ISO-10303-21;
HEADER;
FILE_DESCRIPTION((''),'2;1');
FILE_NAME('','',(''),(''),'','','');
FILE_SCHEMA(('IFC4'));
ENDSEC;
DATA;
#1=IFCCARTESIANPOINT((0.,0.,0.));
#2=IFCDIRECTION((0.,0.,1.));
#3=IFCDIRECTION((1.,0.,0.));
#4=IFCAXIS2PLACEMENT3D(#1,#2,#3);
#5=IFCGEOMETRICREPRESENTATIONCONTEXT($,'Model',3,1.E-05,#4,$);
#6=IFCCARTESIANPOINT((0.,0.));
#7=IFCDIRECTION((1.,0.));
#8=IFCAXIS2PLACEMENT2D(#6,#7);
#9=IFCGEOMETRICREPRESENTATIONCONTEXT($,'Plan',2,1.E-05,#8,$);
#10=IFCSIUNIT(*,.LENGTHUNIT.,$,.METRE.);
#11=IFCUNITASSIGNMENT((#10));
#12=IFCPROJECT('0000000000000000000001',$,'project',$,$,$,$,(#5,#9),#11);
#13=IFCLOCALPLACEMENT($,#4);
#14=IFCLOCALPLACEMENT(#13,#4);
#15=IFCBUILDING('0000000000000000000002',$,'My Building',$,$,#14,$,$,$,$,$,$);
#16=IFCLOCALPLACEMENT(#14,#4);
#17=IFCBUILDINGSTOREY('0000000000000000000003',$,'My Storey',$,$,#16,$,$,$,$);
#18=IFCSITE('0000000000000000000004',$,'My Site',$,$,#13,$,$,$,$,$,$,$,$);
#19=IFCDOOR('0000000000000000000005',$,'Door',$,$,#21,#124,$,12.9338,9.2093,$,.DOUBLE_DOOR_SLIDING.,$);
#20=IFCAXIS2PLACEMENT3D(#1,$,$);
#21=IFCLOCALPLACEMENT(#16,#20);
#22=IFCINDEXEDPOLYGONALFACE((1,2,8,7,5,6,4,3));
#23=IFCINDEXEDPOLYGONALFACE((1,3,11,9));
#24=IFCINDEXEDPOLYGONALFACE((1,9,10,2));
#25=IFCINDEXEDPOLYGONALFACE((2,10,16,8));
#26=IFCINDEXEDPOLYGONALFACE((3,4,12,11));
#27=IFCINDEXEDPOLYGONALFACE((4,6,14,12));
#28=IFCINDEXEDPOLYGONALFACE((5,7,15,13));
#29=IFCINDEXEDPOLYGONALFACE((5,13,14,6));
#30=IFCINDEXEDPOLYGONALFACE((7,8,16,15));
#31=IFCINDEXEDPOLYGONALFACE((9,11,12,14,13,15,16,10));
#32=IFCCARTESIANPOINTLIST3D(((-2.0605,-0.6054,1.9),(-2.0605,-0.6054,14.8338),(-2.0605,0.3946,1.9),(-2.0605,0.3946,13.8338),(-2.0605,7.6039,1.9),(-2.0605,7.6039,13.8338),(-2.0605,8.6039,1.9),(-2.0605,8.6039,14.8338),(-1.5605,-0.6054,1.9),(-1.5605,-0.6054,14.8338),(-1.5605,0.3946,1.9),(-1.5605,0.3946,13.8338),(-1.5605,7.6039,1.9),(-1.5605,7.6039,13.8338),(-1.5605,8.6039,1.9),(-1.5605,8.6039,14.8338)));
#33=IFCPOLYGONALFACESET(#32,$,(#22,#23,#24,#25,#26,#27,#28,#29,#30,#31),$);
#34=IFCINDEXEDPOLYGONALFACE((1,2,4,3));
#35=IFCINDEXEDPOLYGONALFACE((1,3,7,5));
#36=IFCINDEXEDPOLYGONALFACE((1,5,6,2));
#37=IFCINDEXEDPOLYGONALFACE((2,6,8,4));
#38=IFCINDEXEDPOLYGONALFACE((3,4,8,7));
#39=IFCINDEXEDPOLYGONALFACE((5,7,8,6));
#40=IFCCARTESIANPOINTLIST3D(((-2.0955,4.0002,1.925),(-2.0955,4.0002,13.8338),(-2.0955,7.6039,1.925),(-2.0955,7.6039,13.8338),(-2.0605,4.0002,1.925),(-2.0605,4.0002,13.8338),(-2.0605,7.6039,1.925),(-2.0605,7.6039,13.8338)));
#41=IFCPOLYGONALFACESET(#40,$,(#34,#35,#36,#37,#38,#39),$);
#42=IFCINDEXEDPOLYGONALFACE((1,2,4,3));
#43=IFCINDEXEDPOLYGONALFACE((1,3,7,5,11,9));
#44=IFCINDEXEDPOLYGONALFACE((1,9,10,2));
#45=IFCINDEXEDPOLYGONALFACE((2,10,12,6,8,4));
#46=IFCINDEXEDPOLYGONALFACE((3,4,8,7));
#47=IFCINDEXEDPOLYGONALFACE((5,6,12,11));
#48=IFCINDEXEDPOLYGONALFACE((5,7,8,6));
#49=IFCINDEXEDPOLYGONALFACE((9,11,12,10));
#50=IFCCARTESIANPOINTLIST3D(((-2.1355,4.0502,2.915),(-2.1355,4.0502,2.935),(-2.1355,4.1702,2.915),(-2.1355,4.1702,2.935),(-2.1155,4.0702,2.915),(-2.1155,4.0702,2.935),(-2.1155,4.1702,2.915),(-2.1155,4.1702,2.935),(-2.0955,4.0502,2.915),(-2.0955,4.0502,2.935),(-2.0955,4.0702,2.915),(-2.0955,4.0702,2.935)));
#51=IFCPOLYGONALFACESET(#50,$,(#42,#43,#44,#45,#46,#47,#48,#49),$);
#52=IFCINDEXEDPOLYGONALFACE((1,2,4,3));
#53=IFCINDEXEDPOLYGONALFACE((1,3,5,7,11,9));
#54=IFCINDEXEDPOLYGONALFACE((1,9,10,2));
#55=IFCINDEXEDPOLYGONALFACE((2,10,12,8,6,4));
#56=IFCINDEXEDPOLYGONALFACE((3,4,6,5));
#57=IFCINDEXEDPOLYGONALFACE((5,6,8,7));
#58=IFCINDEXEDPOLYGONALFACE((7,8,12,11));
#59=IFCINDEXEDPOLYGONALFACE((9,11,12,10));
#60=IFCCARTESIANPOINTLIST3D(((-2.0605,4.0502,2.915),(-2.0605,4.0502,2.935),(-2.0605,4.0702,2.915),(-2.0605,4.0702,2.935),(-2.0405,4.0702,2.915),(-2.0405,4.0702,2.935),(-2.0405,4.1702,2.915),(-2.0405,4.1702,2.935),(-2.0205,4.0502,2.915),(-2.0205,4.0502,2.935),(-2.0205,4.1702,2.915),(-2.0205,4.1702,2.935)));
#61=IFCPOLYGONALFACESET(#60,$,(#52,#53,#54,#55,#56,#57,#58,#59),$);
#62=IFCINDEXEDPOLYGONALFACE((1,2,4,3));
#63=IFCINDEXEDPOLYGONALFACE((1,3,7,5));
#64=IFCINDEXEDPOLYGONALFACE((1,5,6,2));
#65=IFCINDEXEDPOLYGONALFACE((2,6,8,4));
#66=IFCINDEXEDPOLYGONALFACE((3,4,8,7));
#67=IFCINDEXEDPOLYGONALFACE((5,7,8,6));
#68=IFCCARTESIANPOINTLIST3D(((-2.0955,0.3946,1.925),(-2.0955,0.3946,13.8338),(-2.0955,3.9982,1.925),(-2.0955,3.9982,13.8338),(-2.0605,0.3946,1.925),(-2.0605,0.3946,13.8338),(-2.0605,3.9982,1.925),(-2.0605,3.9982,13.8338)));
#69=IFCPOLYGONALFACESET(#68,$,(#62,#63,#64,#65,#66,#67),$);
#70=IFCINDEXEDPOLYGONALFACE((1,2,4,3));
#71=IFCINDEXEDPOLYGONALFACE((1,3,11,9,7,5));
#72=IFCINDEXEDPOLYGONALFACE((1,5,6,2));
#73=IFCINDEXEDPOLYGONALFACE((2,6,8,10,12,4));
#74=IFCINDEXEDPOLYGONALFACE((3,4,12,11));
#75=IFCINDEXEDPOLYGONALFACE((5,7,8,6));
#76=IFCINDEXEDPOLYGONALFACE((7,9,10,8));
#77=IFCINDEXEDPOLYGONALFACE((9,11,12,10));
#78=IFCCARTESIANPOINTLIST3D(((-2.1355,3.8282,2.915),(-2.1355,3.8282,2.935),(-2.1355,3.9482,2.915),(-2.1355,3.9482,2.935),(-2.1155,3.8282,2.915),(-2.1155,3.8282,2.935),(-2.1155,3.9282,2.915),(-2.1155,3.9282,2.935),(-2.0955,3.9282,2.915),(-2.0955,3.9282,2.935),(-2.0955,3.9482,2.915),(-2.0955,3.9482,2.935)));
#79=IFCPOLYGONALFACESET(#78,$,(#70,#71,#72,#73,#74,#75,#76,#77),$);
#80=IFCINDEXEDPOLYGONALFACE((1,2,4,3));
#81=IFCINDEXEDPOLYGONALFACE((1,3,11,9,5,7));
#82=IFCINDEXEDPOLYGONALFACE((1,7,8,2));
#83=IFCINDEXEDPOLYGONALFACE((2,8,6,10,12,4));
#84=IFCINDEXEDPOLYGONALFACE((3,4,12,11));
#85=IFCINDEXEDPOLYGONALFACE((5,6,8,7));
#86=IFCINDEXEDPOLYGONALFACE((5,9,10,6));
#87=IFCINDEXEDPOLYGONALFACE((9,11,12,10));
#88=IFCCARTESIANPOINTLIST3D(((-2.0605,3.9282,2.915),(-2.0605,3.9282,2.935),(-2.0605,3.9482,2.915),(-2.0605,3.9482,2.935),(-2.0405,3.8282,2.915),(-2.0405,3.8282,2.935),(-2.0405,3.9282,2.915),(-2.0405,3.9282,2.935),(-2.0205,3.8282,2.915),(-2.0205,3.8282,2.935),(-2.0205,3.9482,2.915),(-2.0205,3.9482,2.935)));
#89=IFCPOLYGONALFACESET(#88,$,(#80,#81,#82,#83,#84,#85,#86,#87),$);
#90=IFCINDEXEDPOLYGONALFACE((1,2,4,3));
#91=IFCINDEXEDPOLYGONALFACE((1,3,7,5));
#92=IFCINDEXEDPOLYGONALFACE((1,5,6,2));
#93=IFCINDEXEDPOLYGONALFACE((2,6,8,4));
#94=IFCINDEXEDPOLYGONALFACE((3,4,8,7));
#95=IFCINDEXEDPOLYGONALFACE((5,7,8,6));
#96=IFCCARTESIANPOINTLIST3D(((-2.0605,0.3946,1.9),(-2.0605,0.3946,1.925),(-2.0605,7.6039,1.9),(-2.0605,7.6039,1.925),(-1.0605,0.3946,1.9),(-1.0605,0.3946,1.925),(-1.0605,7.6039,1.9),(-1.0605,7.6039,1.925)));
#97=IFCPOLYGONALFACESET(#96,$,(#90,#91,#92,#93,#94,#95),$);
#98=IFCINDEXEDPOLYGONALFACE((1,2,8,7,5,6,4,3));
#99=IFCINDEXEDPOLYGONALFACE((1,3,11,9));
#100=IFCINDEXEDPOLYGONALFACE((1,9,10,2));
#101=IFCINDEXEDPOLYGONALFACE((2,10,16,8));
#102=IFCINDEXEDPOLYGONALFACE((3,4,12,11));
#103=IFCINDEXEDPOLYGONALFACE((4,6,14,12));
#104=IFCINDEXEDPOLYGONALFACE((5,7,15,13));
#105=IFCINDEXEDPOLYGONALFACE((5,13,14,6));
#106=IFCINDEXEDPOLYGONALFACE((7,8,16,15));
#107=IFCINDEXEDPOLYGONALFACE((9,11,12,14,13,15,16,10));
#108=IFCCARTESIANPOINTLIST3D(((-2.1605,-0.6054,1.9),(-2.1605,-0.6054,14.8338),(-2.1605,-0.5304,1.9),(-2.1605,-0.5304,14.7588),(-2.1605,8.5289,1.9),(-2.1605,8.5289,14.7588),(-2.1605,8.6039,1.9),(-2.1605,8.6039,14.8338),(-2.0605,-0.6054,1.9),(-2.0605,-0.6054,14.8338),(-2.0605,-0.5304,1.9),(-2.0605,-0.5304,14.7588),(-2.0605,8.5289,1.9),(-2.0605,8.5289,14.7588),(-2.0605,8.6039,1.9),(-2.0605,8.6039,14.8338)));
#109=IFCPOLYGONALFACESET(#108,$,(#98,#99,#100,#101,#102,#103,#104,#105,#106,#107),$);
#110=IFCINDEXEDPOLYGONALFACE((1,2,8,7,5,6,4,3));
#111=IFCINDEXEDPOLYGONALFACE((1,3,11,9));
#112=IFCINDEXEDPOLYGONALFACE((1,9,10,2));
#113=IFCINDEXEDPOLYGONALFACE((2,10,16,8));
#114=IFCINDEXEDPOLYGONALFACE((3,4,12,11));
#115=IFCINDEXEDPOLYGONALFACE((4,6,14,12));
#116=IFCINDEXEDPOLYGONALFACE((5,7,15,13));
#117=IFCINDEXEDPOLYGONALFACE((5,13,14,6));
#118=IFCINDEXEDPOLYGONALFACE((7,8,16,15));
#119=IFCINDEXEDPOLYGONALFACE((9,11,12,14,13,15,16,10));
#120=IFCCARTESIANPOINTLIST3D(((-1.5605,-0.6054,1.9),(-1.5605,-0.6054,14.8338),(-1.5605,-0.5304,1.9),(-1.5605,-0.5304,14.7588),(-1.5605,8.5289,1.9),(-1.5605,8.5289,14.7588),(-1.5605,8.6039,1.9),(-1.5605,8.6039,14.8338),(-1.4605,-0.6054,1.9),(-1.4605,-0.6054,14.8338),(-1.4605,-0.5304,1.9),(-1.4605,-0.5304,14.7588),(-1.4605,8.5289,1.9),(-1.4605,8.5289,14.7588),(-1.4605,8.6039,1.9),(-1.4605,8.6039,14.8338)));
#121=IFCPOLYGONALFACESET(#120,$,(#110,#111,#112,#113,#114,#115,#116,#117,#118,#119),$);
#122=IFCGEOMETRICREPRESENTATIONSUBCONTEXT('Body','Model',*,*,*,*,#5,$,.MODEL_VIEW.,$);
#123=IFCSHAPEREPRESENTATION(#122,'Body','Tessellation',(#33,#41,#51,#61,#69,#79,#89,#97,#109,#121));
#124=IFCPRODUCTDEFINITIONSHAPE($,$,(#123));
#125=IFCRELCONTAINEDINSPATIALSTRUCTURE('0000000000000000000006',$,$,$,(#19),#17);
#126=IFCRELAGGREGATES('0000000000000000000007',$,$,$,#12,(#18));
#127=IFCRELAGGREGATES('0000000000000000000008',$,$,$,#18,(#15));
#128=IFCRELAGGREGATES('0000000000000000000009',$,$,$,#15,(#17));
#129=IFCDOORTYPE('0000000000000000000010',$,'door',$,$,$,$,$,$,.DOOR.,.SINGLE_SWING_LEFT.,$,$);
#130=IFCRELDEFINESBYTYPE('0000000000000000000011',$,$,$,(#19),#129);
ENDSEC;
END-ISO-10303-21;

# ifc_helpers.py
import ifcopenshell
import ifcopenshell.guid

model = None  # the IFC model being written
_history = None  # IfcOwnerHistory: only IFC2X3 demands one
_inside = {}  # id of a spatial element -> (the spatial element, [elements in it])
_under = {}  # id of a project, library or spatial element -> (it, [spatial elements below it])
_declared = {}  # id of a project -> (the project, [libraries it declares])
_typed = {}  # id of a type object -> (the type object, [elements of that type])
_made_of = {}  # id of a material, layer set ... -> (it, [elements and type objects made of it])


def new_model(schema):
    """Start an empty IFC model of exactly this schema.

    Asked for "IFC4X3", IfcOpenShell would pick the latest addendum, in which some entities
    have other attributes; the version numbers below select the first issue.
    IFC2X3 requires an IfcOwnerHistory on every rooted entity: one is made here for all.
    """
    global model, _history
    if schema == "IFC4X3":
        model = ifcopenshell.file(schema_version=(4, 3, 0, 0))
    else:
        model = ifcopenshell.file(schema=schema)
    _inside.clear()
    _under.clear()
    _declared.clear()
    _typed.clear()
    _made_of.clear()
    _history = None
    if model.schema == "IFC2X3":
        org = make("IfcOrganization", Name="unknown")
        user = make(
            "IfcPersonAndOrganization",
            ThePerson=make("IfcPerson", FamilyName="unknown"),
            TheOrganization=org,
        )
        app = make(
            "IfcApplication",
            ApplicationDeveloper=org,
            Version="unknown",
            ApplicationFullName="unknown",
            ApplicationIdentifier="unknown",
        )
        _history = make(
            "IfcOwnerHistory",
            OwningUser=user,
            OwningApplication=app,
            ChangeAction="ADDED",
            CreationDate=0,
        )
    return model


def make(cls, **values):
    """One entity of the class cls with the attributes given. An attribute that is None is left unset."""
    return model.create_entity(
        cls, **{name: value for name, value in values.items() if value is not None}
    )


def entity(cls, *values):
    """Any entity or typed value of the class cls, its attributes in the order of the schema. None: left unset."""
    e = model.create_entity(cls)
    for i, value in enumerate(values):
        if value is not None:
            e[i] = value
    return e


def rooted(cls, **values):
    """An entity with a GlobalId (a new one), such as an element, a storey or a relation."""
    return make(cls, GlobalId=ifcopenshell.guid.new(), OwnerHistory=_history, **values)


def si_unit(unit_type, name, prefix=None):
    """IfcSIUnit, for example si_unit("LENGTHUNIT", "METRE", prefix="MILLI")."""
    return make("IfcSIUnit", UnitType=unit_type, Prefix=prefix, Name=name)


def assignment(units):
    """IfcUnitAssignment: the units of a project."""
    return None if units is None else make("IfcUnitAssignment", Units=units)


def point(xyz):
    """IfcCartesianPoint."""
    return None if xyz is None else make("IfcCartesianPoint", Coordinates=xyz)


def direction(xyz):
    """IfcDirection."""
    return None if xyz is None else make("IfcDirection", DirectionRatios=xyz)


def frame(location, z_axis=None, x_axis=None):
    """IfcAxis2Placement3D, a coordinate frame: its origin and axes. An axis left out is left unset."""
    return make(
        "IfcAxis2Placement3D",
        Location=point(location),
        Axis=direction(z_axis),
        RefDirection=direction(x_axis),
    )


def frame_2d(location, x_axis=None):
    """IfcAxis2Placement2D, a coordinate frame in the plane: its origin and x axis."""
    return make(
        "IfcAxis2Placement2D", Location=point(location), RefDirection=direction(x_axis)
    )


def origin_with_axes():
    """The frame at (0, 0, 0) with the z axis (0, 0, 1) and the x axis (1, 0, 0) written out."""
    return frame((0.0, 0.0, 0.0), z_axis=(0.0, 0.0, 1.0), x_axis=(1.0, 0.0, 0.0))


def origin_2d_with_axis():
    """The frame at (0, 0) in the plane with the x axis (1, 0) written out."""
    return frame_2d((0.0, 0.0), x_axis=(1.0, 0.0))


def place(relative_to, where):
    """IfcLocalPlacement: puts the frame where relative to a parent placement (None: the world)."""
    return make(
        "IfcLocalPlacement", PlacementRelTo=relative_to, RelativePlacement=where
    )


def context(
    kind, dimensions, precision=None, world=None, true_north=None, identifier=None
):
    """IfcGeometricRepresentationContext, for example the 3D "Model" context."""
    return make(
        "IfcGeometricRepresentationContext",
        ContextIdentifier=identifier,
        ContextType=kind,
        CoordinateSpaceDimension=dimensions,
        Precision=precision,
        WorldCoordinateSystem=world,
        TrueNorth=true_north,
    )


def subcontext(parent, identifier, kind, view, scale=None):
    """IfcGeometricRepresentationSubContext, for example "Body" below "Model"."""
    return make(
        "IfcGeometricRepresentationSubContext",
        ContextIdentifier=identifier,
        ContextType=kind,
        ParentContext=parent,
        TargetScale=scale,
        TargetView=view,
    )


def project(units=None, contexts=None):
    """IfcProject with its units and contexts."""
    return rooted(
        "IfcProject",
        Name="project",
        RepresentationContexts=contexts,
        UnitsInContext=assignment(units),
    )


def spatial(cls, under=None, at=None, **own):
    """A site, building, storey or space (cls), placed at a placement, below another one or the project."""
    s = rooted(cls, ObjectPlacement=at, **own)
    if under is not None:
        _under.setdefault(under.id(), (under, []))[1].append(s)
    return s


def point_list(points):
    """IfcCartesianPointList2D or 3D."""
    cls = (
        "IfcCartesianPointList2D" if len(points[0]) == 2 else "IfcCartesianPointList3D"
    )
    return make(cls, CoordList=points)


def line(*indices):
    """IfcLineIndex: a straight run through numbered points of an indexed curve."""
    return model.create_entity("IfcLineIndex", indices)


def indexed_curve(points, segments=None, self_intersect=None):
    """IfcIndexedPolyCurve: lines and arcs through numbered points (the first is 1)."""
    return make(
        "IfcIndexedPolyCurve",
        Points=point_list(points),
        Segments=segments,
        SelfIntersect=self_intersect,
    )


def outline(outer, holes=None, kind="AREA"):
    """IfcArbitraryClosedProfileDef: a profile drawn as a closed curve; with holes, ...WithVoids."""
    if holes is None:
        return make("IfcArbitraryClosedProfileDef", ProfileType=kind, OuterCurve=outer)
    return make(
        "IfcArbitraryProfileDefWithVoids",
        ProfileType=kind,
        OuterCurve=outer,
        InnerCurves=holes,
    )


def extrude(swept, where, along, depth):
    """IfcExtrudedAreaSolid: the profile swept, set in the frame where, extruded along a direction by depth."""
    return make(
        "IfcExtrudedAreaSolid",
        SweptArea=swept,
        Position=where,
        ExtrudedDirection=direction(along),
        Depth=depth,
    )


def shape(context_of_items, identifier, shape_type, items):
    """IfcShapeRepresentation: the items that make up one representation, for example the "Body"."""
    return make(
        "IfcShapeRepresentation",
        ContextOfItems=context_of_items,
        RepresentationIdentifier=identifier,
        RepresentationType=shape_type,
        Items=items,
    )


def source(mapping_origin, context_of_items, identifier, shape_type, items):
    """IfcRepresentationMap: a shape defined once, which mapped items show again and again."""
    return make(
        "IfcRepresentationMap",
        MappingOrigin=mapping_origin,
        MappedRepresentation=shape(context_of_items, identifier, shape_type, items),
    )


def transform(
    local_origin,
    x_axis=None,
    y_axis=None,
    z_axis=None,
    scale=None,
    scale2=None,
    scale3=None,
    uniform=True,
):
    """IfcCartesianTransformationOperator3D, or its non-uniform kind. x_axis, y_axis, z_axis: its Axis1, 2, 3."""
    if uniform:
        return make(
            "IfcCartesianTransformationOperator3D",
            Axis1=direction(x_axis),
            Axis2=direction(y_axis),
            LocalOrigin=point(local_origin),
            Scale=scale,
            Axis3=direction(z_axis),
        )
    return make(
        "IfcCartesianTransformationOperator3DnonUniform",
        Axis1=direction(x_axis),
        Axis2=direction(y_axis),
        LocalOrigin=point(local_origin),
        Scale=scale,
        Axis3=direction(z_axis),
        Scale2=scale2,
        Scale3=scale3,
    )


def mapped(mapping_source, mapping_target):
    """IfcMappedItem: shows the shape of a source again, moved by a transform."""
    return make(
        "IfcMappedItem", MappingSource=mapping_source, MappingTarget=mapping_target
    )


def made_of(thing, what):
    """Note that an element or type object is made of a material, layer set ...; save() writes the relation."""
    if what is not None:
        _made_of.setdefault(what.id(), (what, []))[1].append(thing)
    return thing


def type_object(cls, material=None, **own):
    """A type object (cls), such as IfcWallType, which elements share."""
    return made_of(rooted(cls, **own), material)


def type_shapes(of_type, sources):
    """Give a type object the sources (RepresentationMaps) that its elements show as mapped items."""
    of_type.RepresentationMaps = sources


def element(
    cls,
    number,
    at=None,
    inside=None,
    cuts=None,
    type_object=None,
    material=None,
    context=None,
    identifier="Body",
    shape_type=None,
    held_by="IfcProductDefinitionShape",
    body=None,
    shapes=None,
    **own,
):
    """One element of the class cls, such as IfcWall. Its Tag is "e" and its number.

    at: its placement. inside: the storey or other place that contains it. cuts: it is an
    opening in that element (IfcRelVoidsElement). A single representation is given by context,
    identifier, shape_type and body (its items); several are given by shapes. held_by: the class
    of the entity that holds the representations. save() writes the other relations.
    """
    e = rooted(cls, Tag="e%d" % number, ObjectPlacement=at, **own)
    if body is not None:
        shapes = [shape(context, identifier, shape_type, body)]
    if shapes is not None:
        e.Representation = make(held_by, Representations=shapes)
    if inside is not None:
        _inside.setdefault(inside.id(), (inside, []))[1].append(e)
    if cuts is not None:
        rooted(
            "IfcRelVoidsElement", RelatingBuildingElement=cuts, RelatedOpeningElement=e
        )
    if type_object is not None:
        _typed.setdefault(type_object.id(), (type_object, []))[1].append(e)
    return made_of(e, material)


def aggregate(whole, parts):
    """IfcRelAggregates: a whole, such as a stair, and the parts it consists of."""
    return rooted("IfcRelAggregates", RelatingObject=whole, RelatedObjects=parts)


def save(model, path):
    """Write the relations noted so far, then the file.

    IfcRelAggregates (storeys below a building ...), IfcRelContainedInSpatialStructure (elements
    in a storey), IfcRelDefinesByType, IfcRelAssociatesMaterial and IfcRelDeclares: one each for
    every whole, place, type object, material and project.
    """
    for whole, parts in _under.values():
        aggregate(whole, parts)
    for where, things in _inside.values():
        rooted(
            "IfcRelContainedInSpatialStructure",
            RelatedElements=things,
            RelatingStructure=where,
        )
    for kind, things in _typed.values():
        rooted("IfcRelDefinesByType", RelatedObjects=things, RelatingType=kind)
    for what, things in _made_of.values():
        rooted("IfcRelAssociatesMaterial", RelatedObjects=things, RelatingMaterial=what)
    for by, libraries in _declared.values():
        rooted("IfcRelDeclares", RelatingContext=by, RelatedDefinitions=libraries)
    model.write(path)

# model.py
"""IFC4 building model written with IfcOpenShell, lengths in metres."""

from ifc_helpers import new_model, entity, si_unit, frame, origin_with_axes, origin_2d_with_axis, place, context, subcontext, project, spatial, line, indexed_curve, outline, extrude, shape, source, transform, mapped, type_object, type_shapes, element, save


model = new_model("IFC4")

# Units and contexts
model_context = context("Model", 3, precision=1e-05, world=origin_with_axes())
plan_context = context("Plan", 2, precision=1e-05, world=origin_2d_with_axis())
body_context_1 = subcontext(model_context, "Body", "Model", "MODEL_VIEW")
body_context_2 = subcontext(plan_context, "Body", "Plan", "PLAN_VIEW")
ifc_project = project(units=[si_unit("LENGTHUNIT", "METRE")], contexts=[model_context, plan_context])

# Site, building, storey
site_placement = place(None, origin_with_axes())
site = spatial("IfcSite", under=ifc_project, at=site_placement, Name="My Site")
building_placement = place(site_placement, origin_with_axes())
building = spatial("IfcBuilding", under=site, at=building_placement, Name="My Building")
storey_placement = place(building_placement, origin_with_axes())
storey = spatial("IfcBuildingStorey", under=building, at=storey_placement, Name="My Storey")

# Door
door_type = type_object("IfcDoorType", Name="door", OperationType="SINGLE_SWING_LEFT", PredefinedType="DOOR")
shared_shape_1 = source(origin_with_axes(), body_context_1, "Body", "SweptSolid", [
    extrude(outline(indexed_curve([(0.0, 0.0), (0.0, 12.9338), (9.2093, 12.9338), (9.2093, 0.0), (8.2093, 0.0), (8.2093, 11.9338), (1.0, 11.9338), (1.0, 0.0)], segments=[line(1, 2, 3, 4, 5, 6, 7, 8, 1)])), frame((0.0, 0.0, 0.0), z_axis=(0.0, -1.0, 0.0), x_axis=(1.0, 0.0, 0.0)), (0.0, 0.0, -1.0), 0.5),
    extrude(outline(indexed_curve([(0.0, 0.0), (3.6036, 0.0), (3.6036, 0.035), (0.0, 0.035)], segments=[line(1, 2, 3, 4, 1)])), frame((1.0, -0.035, 0.025), z_axis=(0.0, 0.0, 1.0), x_axis=(1.0, 0.0, 0.0)), (0.0, 0.0, 1.0), 11.9088),
    extrude(outline(indexed_curve([(0.0, 0.0), (0.0, -0.04), (-0.12, -0.04), (-0.12, -0.02), (-0.02, -0.02), (-0.02, 0.0)], segments=[line(1, 2, 3, 4, 5, 6, 1)])), frame((4.5536, -0.035, 1.015), z_axis=(0.0, 0.0, 1.0), x_axis=(1.0, 0.0, 0.0)), (0.0, 0.0, 1.0), 0.02),
    extrude(outline(indexed_curve([(0.0, 0.0), (0.0, 0.04), (-0.12, 0.04), (-0.12, 0.02), (-0.02, 0.02), (-0.02, 0.0)], segments=[line(1, 2, 3, 4, 5, 6, 1)])), frame((4.5536, 0.0, 1.015), z_axis=(0.0, 0.0, 1.0), x_axis=(1.0, 0.0, 0.0)), (0.0, 0.0, 1.0), 0.02),
    extrude(outline(indexed_curve([(0.0, 0.0), (-3.6036, 0.0), (-3.6036, 0.035), (0.0, 0.035)], segments=[line(1, 2, 3, 4, 1)])), frame((8.2093, -0.035, 0.025), z_axis=(0.0, 0.0, 1.0), x_axis=(1.0, 0.0, 0.0)), (0.0, 0.0, 1.0), 11.9088),
    extrude(outline(indexed_curve([(0.0, 0.0), (0.0, -0.04), (0.12, -0.04), (0.12, -0.02), (0.02, -0.02), (0.02, 0.0)], segments=[line(1, 2, 3, 4, 5, 6, 1)])), frame((4.6556, -0.035, 1.015), z_axis=(0.0, 0.0, 1.0), x_axis=(1.0, 0.0, 0.0)), (0.0, 0.0, 1.0), 0.02),
    extrude(outline(indexed_curve([(0.0, 0.0), (0.0, 0.04), (0.12, 0.04), (0.12, 0.02), (0.02, 0.02), (0.02, 0.0)], segments=[line(1, 2, 3, 4, 5, 6, 1)])), frame((4.6556, 0.0, 1.015), z_axis=(0.0, 0.0, 1.0), x_axis=(1.0, 0.0, 0.0)), (0.0, 0.0, 1.0), 0.02),
    extrude(outline(indexed_curve([(0.0, 0.0), (7.2093, 0.0), (7.2093, 1.0), (0.0, 1.0)], segments=[line(1, 2, 3, 4, 1)])), frame((1.0, 0.0, 0.0), z_axis=(0.0, 0.0, 1.0), x_axis=(1.0, 0.0, 0.0)), (0.0, 0.0, 1.0), 0.025),
    extrude(outline(indexed_curve([(0.0, 0.0), (0.0, 12.9338), (9.2093, 12.9338), (9.2093, 0.0), (9.1343, 0.0), (9.1343, 12.8588), (0.075, 12.8588), (0.075, 0.0)], segments=[line(1, 2, 3, 4, 5, 6, 7, 8, 1)])), frame((0.0, -0.1, 0.0), z_axis=(0.0, -1.0, 0.0), x_axis=(1.0, 0.0, 0.0)), (0.0, 0.0, -1.0), 0.1),
    extrude(outline(indexed_curve([(0.0, 0.0), (0.0, 12.9338), (9.2093, 12.9338), (9.2093, 0.0), (9.1343, 0.0), (9.1343, 12.8588), (0.075, 12.8588), (0.075, 0.0)], segments=[line(1, 2, 3, 4, 5, 6, 7, 8, 1)])), frame((0.0, 0.5, 0.0), z_axis=(0.0, -1.0, 0.0), x_axis=(1.0, 0.0, 0.0)), (0.0, 0.0, -1.0), 0.1),
])
shared_shape_2 = source(origin_with_axes(), body_context_2, "Body", "Curve2D", [
    entity("IfcIndexedPolyCurve", entity("IfcCartesianPointList2D", [[0.0, 0.0], [1.0, 0.0], [1.0, 0.5], [0.0, 0.5]]), [entity("IfcLineIndex", [1, 2, 3, 4, 1])]),
    entity("IfcIndexedPolyCurve", entity("IfcCartesianPointList2D", [[9.2093, 0.0], [8.2093, 0.0], [8.2093, 0.5], [9.2093, 0.5]]), [entity("IfcLineIndex", [1, 2, 3, 4, 1])]),
    entity("IfcIndexedPolyCurve", entity("IfcCartesianPointList2D", [[-0.8023, -0.035], [2.8023, -0.035], [2.8023, 0.0], [-0.8023, 0.0]]), [entity("IfcLineIndex", [1, 2, 3, 4, 1])]),
    entity("IfcIndexedPolyCurve", entity("IfcCartesianPointList2D", [[10.0116, -0.035], [6.407, -0.035], [6.407, 0.0], [10.0116, 0.0]]), [entity("IfcLineIndex", [1, 2, 3, 4, 1])]),
])
type_shapes(door_type, [shared_shape_1, shared_shape_2])
door_placement = place(storey_placement, frame((-2.0605, 8.6039, 1.9), z_axis=(0.0, 0.0, 1.0), x_axis=(0.0, -1.0, 0.0)))
element("IfcDoor", 1, at=door_placement, inside=storey, type_object=door_type, Name="Door", OperationType="DOUBLE_DOOR_SLIDING", OverallHeight=12.9338, OverallWidth=9.2093, shapes=[
    shape(body_context_1, "Body", "MappedRepresentation", [mapped(shared_shape_1, transform((0.0, 0.0, 0.0), x_axis=(1.0, 0.0, 0.0), y_axis=(0.0, 1.0, 0.0), z_axis=(0.0, 0.0, 1.0), scale=1.0))]),
    shape(body_context_2, "Body", "MappedRepresentation", [mapped(shared_shape_2, transform((0.0, 0.0, 0.0), x_axis=(1.0, 0.0, 0.0), y_axis=(0.0, 1.0, 0.0), z_axis=(0.0, 0.0, 1.0), scale=1.0))]),
])

save(model, "model.ifc")
